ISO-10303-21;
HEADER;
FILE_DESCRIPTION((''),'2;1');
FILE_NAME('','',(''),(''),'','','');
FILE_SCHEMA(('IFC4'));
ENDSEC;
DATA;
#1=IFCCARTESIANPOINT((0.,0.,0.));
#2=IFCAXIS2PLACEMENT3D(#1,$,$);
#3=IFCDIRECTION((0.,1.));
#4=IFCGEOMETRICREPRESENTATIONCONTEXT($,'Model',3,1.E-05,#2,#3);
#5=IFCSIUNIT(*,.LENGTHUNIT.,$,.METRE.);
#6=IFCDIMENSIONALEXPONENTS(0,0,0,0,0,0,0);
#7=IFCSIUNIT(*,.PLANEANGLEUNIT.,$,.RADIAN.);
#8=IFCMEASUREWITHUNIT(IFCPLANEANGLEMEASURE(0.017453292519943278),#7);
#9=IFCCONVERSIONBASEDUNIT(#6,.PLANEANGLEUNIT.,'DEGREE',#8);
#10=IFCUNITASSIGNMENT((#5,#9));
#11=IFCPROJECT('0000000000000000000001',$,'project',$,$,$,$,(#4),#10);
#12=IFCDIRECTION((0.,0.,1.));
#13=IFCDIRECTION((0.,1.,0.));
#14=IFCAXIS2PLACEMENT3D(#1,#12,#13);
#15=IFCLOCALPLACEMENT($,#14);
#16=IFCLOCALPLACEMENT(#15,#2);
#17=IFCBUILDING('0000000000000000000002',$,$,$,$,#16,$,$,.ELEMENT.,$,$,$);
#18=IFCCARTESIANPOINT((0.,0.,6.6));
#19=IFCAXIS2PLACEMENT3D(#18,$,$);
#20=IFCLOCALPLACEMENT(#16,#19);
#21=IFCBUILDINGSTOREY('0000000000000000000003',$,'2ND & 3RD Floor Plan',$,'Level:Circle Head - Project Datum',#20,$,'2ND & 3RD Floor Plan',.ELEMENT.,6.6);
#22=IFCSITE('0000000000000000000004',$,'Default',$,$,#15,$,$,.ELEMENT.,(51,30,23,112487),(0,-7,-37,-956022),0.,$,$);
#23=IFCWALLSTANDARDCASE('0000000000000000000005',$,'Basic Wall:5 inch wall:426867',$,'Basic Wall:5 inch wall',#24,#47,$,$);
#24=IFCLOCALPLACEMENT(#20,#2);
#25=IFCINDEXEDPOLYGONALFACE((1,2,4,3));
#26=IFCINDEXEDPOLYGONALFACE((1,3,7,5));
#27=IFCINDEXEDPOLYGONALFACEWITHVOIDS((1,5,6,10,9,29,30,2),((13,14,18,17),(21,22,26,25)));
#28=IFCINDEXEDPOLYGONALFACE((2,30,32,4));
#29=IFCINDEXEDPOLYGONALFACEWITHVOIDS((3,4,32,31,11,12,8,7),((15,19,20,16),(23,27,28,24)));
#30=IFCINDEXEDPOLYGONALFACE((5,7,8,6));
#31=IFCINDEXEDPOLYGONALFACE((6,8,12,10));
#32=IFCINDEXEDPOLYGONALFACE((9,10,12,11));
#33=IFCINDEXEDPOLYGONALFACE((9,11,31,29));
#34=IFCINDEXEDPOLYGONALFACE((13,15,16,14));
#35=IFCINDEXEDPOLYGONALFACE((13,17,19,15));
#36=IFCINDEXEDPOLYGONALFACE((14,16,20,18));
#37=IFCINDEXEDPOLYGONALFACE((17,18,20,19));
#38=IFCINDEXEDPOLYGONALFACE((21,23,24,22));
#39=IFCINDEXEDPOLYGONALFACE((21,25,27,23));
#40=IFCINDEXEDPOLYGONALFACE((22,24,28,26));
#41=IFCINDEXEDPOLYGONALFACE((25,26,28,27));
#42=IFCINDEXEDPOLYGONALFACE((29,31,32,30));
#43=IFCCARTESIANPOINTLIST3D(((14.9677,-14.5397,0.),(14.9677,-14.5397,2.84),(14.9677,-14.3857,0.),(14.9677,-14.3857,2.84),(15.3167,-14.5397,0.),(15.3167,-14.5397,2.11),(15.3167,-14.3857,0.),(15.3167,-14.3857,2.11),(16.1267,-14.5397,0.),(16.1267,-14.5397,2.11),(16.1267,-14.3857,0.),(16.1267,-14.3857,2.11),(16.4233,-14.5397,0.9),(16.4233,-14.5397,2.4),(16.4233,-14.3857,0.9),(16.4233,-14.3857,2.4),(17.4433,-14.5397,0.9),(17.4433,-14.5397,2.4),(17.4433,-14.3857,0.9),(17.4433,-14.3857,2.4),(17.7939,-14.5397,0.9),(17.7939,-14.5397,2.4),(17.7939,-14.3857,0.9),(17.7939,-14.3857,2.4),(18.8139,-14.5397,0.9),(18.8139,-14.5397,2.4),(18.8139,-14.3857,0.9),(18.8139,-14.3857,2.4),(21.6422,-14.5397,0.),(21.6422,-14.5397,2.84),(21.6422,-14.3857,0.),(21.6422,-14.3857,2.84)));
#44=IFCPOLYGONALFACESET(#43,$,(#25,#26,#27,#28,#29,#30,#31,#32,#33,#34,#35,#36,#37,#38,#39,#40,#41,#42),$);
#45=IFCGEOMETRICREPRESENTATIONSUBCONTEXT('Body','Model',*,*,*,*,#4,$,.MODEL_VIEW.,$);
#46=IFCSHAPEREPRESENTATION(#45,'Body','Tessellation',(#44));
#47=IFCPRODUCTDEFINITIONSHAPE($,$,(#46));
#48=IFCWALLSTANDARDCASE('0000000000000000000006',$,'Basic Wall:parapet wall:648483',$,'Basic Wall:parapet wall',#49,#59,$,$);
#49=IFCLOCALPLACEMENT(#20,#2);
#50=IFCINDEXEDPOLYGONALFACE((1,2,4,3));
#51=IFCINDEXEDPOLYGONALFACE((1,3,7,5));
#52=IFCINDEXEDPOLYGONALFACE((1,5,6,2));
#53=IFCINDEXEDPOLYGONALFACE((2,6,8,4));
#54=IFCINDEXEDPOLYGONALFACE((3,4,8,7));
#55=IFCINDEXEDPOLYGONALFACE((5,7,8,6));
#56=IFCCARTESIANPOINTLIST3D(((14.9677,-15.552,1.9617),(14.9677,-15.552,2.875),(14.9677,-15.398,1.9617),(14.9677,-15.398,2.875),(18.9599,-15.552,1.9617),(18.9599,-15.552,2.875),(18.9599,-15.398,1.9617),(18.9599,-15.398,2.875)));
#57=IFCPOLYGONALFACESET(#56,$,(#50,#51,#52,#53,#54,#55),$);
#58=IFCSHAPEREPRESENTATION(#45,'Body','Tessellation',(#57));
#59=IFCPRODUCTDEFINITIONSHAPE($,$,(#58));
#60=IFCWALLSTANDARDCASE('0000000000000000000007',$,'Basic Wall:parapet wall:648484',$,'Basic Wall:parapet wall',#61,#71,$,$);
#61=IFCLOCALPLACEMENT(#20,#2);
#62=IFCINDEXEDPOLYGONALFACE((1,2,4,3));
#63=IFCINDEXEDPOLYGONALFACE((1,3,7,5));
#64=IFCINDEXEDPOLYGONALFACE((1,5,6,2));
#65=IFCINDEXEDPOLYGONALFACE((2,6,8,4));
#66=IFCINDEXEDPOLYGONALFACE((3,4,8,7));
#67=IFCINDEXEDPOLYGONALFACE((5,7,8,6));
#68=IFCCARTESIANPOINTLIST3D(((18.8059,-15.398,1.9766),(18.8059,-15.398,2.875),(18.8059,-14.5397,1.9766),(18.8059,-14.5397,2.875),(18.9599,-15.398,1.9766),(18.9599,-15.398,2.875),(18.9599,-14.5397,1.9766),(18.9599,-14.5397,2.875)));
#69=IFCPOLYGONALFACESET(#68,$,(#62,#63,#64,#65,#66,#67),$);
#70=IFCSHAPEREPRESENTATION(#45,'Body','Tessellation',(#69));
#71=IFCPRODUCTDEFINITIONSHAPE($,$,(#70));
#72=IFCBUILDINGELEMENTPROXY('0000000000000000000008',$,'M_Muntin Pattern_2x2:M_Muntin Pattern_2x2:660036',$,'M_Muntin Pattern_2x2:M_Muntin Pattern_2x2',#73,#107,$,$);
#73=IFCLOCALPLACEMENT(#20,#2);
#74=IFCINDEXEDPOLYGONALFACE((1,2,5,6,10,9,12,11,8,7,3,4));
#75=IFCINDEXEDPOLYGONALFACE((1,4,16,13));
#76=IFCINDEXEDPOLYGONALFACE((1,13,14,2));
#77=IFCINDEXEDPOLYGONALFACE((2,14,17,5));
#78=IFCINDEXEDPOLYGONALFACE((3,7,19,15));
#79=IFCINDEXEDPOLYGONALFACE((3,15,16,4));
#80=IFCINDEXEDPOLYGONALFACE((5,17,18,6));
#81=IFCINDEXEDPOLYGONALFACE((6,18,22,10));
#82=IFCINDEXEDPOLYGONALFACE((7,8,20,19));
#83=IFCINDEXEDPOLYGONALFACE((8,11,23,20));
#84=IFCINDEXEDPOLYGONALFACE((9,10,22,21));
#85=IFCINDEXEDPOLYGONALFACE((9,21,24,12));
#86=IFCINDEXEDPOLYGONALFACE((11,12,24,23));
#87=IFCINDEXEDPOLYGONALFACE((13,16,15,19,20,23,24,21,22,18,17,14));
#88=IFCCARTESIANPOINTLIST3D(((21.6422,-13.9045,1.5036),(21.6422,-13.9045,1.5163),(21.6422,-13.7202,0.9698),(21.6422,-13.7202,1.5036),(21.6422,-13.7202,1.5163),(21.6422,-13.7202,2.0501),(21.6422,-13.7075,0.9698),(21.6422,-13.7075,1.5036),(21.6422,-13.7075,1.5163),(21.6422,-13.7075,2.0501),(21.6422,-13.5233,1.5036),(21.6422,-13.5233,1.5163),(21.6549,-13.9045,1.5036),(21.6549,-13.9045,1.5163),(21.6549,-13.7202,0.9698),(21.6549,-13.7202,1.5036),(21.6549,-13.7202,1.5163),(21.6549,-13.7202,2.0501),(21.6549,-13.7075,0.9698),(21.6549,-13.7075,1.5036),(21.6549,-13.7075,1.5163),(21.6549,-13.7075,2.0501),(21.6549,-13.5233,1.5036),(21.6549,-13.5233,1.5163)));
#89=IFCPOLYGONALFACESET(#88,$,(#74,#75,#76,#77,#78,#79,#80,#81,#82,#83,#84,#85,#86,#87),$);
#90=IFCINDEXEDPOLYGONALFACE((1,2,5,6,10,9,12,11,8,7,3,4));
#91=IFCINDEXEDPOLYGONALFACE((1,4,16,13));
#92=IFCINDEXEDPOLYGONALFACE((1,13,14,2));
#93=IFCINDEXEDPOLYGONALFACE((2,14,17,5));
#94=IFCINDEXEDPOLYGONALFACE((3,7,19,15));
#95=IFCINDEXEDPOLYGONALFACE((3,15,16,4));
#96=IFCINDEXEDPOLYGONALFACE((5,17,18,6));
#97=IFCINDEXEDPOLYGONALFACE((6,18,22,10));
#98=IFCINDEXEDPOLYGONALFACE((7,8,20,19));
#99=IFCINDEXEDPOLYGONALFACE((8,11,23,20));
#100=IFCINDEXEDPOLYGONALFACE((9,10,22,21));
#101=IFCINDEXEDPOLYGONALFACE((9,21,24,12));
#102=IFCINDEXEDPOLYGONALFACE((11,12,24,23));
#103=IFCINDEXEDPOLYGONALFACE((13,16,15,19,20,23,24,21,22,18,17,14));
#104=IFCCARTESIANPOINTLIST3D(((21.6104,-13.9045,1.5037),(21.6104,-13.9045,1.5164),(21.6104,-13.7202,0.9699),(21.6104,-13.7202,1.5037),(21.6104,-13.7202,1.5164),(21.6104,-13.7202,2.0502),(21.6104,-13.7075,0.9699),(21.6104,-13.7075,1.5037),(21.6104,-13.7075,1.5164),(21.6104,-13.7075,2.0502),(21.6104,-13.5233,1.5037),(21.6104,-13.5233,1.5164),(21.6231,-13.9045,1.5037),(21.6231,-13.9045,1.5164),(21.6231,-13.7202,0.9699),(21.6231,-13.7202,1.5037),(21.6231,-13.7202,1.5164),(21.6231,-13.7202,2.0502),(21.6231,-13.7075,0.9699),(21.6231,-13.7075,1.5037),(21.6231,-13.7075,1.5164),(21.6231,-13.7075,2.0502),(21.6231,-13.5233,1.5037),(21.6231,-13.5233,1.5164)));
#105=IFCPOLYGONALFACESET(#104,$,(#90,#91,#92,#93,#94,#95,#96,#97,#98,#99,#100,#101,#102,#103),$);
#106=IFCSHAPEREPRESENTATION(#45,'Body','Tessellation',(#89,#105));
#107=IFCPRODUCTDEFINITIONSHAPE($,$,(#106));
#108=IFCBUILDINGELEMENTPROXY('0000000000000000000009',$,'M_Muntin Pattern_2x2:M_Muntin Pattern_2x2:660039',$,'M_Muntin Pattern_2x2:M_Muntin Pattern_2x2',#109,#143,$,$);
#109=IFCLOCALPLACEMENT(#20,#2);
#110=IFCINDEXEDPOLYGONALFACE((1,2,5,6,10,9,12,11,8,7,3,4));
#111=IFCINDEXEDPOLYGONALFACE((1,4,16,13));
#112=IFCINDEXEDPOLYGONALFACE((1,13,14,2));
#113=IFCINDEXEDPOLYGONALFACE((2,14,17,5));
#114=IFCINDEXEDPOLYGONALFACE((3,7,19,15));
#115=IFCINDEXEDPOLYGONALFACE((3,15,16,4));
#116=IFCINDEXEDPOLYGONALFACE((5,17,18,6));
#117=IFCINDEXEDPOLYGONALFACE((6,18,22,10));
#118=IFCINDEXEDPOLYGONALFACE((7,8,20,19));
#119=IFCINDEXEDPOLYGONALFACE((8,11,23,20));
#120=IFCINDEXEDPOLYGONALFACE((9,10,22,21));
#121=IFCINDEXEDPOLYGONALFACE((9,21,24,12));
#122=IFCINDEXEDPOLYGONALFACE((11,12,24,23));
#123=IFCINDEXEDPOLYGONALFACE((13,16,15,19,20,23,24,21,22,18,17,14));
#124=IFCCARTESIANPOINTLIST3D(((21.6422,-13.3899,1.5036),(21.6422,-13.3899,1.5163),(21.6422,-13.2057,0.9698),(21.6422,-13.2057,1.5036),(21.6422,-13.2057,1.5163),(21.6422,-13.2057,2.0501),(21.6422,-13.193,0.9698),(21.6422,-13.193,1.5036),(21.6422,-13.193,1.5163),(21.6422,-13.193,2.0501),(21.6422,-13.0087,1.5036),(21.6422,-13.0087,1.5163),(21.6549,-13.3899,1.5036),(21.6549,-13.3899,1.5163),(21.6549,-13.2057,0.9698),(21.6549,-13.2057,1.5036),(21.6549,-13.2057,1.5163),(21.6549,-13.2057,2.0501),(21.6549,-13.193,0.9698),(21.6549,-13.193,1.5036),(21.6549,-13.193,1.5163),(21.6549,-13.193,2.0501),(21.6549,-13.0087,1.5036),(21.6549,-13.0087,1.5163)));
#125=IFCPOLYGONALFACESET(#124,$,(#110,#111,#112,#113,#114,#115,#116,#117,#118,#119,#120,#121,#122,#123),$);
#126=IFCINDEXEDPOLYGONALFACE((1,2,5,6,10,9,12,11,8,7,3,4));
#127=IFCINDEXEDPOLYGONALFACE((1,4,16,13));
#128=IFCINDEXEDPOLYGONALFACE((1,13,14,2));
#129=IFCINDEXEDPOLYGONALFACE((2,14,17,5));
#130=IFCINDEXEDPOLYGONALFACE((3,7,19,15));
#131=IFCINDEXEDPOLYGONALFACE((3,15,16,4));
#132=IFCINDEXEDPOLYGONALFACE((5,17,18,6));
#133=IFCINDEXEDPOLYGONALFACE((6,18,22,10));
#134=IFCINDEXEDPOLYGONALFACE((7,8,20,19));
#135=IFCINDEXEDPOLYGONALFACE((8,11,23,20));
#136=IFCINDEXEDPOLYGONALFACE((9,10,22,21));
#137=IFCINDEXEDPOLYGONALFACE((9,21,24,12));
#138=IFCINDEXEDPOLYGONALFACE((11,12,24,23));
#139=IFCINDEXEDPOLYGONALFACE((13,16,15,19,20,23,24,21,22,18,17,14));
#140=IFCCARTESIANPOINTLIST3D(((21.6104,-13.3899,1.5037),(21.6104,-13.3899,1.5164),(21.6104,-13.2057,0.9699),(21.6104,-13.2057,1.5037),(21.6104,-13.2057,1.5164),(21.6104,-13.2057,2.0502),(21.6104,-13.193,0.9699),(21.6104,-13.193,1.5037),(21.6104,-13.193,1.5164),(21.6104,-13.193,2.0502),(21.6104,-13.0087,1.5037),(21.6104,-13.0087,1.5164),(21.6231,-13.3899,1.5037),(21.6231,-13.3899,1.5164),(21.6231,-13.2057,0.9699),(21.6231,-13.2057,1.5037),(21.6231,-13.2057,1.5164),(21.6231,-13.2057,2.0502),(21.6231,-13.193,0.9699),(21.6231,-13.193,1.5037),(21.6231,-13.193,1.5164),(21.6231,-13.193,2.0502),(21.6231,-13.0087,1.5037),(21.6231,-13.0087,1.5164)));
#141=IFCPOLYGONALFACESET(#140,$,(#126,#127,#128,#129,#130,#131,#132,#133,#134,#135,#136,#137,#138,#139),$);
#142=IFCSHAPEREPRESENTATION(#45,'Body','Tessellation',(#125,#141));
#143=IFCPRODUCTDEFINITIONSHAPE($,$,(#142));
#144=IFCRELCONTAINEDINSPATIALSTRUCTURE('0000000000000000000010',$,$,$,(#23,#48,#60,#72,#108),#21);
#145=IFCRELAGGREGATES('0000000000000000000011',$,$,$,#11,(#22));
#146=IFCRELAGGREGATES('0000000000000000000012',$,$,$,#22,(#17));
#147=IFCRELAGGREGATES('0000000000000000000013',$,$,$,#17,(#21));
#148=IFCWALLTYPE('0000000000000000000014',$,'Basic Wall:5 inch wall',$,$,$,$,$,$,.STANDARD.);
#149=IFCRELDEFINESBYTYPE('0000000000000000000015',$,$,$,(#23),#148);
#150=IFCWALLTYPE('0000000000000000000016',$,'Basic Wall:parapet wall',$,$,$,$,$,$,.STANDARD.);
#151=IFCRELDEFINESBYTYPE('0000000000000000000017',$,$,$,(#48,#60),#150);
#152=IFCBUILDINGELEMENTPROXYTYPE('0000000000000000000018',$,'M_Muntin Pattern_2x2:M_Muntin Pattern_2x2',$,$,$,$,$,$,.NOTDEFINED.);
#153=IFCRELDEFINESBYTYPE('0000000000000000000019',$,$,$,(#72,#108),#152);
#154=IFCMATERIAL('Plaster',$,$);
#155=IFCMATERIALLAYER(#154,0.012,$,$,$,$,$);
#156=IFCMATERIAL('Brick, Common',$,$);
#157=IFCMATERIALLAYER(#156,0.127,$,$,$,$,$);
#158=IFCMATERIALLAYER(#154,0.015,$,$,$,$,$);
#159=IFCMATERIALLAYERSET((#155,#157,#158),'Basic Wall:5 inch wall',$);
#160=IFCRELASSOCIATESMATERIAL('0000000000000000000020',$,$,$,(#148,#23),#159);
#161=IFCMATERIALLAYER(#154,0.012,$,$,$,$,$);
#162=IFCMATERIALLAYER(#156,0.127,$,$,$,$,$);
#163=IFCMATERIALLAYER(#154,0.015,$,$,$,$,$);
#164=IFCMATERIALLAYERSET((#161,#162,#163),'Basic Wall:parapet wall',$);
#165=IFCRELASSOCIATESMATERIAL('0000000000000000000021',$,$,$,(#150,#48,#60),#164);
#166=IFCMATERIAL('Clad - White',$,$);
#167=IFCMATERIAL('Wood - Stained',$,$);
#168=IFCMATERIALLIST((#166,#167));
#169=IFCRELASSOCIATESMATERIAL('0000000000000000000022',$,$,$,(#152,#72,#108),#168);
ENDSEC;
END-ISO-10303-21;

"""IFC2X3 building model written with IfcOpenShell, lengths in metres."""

from ifc_helpers import new_model, entity, si_unit, converted_unit, direction, frame, frame_2d, origin, place, context, subcontext, project, spatial, polyline, rectangle, outline, extrude, clip, bounded_halfspace, source, transform, mapped, material, material_list, layer, layer_set, layer_usage, type_object, type_shapes, element, save


model = new_model("IFC2X3")

# Units and contexts
model_context = context("Model", 3, precision=1e-05, world=origin(), true_north=direction((0.0, 1.0)))
body_context = subcontext(model_context, "Body", "Model", "MODEL_VIEW")
ifc_project = project(units=[si_unit("LENGTHUNIT", "METRE"), converted_unit("PLANEANGLEUNIT", "DEGREE", entity("IfcPlaneAngleMeasure", 0.017453292519943278), si_unit("PLANEANGLEUNIT", "RADIAN"), dimensions=[0, 0, 0, 0, 0, 0, 0])], contexts=[model_context])

# Site, building, storey
site_placement = place(None, frame((0.0, 0.0, 0.0), z_axis=(0.0, 0.0, 1.0), x_axis=(0.0, 1.0, 0.0)))
site = spatial("IfcSite", under=ifc_project, at=site_placement, Name="Default", CompositionType="ELEMENT", RefLatitude=(51, 30, 23, 112487), RefLongitude=(0, -7, -37, -956022), RefElevation=0.0)
building_placement = place(site_placement, origin())
building = spatial("IfcBuilding", under=site, at=building_placement, CompositionType="ELEMENT")
storey_placement = place(building_placement, frame((0.0, 0.0, 6.6)))
storey = spatial("IfcBuildingStorey", under=building, at=storey_placement, Name="2ND & 3RD Floor Plan", ObjectType="Level:Circle Head - Project Datum", LongName="2ND & 3RD Floor Plan", CompositionType="ELEMENT", Elevation=6.6)

# Wall, openings
ifc_material_1 = material(Name="Plaster")
ifc_layer_1 = layer(ifc_material_1, 0.012)
ifc_material_2 = material(Name="Brick, Common")
ifc_layer_2 = layer(ifc_material_2, 0.127)
ifc_layer_3 = layer(ifc_material_1, 0.015)
ifc_layer_set_1 = layer_set([ifc_layer_1, ifc_layer_2, ifc_layer_3], Name="Basic Wall:5 inch wall")
ifc_layer_usage_1 = layer_usage(ifc_layer_set_1, "AXIS2", "POSITIVE", -0.077)
wall_type_1 = type_object("IfcWallType", Name="Basic Wall:5 inch wall", PredefinedType="STANDARD", material=ifc_layer_set_1)
wall_1_placement = place(storey_placement, frame((14.9677, -14.4627, 0.0)))
wall_1 = element("IfcWallStandardCase", 1, at=wall_1_placement, inside=storey, type_object=wall_type_1, material=ifc_layer_usage_1, Name="Basic Wall:5 inch wall:426867", ObjectType="Basic Wall:5 inch wall", context=body_context, shape_type="SweptSolid", body=[
    extrude(rectangle(XDim=6.6745, YDim=0.154, at=frame_2d((3.3372, 0.0), x_axis=(1.0, 0.0))), origin(), (0.0, 0.0, 1.0), 2.84),
])
opening_1_placement = place(wall_1_placement, frame((0.3491, -0.077, 0.0)))
element("IfcOpeningElement", 2, at=opening_1_placement, cuts=wall_1, ObjectType="Opening", context=body_context, shape_type="SweptSolid", body=[
    extrude(rectangle(XDim=2.11, YDim=0.81, at=frame_2d((1.055, 0.405), x_axis=(1.0, 0.0))), frame((0.0, 0.0, 0.0), z_axis=(0.0, 1.0, 0.0), x_axis=(0.0, 0.0, 1.0)), (0.0, 0.0, 1.0), 0.154),
])
opening_2_placement = place(wall_1_placement, frame((2.4757, 0.077, 0.9)))
element("IfcOpeningElement", 3, at=opening_2_placement, cuts=wall_1, ObjectType="Opening", context=body_context, shape_type="SweptSolid", body=[
    extrude(rectangle(XDim=1.5, YDim=1.02, at=frame_2d((0.75, 0.51), x_axis=(-1.0, 0.0))), frame((0.0, 0.0, 0.0), z_axis=(0.0, -1.0, 0.0), x_axis=(0.0, 0.0, 1.0)), (0.0, 0.0, 1.0), 0.154),
])
opening_3_placement = place(wall_1_placement, frame((3.8463, 0.077, 0.9)))
element("IfcOpeningElement", 4, at=opening_3_placement, cuts=wall_1, ObjectType="Opening", context=body_context, shape_type="SweptSolid", body=[
    extrude(rectangle(XDim=1.5, YDim=1.02, at=frame_2d((0.75, 0.51), x_axis=(-1.0, 0.0))), frame((0.0, 0.0, 0.0), z_axis=(0.0, -1.0, 0.0), x_axis=(0.0, 0.0, 1.0)), (0.0, 0.0, 1.0), 0.154),
])

# Walls
ifc_layer_4 = layer(ifc_material_1, 0.012)
ifc_layer_5 = layer(ifc_material_2, 0.127)
ifc_layer_6 = layer(ifc_material_1, 0.015)
ifc_layer_set_2 = layer_set([ifc_layer_4, ifc_layer_5, ifc_layer_6], Name="Basic Wall:parapet wall")
ifc_layer_usage_2 = layer_usage(ifc_layer_set_2, "AXIS2", "NEGATIVE", 0.077)
wall_type_2 = type_object("IfcWallType", Name="Basic Wall:parapet wall", PredefinedType="STANDARD", material=ifc_layer_set_2)
wall_2_placement = place(storey_placement, frame((14.9677, -15.475, 1.9617)))
element("IfcWallStandardCase", 5, at=wall_2_placement, inside=storey, type_object=wall_type_2, material=ifc_layer_usage_2, Name="Basic Wall:parapet wall:648483", ObjectType="Basic Wall:parapet wall", context=body_context, shape_type="Clipping", body=[
    clip(extrude(rectangle(XDim=3.9923, YDim=0.154, at=frame_2d((1.9961, 0.0), x_axis=(-1.0, 0.0))), origin(), (0.0, 0.0, 1.0), 0.9133), bounded_halfspace(frame((0.0, -0.077, 0.9133), z_axis=(0.0, 0.0, -1.0), x_axis=(0.0, -1.0, 0.0)), True, frame((0.0, -0.077, 0.9133)), polyline([(0.0, 0.0), (3.9923, 0.0), (3.9923, 0.154), (3.8383, 0.154), (0.0, 0.154), (0.0, 0.0)]))),
])
ifc_layer_usage_3 = layer_usage(ifc_layer_set_2, "AXIS2", "NEGATIVE", 0.077)
wall_3_placement = place(storey_placement, frame((18.8829, -15.398, 1.9766), z_axis=(0.0, 0.0, 1.0), x_axis=(0.0, 1.0, 0.0)))
element("IfcWallStandardCase", 6, at=wall_3_placement, inside=storey, type_object=wall_type_2, material=ifc_layer_usage_3, Name="Basic Wall:parapet wall:648484", ObjectType="Basic Wall:parapet wall", context=body_context, shape_type="Clipping", body=[
    clip(extrude(rectangle(XDim=0.8583, YDim=0.154, at=frame_2d((0.4291, 0.0), x_axis=(-1.0, 0.0))), origin(), (0.0, 0.0, 1.0), 0.8984), bounded_halfspace(frame((0.0, -0.077, 0.8984), z_axis=(0.0, 0.0, -1.0), x_axis=(-1.0, 0.0, 0.0)), True, frame((0.0, -0.077, 0.8984)), polyline([(0.0, 0.0), (0.8583, 0.0), (0.8583, 0.154), (0.0, 0.154), (0.0, 0.0)]))),
])

# Building element proxies
ifc_material_3 = material(Name="Clad - White")
ifc_material_4 = material(Name="Wood - Stained")
ifc_material_list = material_list([ifc_material_3, ifc_material_4])
building_element_proxy_type_1 = type_object("IfcBuildingElementProxyType", Name="M_Muntin Pattern_2x2:M_Muntin Pattern_2x2", PredefinedType="NOTDEFINED", material=ifc_material_list)
shared_shape_1 = source(origin(), body_context, "Body", "SweptSolid", [
    extrude(outline(polyline([(0.0064, -0.0064), (0.5401, -0.0064), (0.5401, 0.0063), (0.0064, 0.0063), (0.0064, 0.1906), (-0.0063, 0.1906), (-0.0063, 0.0063), (-0.5402, 0.0063), (-0.5402, -0.0064), (-0.0063, -0.0064), (-0.0063, -0.1906), (0.0064, -0.1906), (0.0064, -0.0064)])), frame((0.0, -0.0222, 0.5401), z_axis=(0.0, 1.0, 0.0), x_axis=(0.0, 0.0, 1.0)), (0.0, 0.0, 1.0), 0.0127),
    extrude(outline(polyline([(0.0064, -0.0064), (0.5402, -0.0064), (0.5402, 0.0063), (0.0064, 0.0063), (0.0064, 0.1906), (-0.0063, 0.1906), (-0.0063, 0.0063), (-0.5402, 0.0063), (-0.5402, -0.0064), (-0.0063, -0.0064), (-0.0063, -0.1906), (0.0064, -0.1906), (0.0064, -0.0064)])), frame((0.0, 0.0095, 0.5402), z_axis=(0.0, 1.0, 0.0), x_axis=(0.0, 0.0, 1.0)), (0.0, 0.0, 1.0), 0.0127),
])
type_shapes(building_element_proxy_type_1, [shared_shape_1])
for number, where, z_axis, x_axis, name in (
    (7, (21.6326, -13.7139, 0.9699), (0.0, 0.0, 1.0), (0.0, 1.0, 0.0), "M_Muntin Pattern_2x2:M_Muntin Pattern_2x2:660036"),
    (8, (21.6326, -13.1993, 0.9699), (0.0, 0.0, 1.0), (0.0, 1.0, 0.0), "M_Muntin Pattern_2x2:M_Muntin Pattern_2x2:660039"),
):
    element("IfcBuildingElementProxy", number, at=place(storey_placement, frame(where, z_axis=z_axis, x_axis=x_axis)), inside=storey, type_object=building_element_proxy_type_1, material=ifc_material_list, Name=name, ObjectType="M_Muntin Pattern_2x2:M_Muntin Pattern_2x2", context=body_context, shape_type="MappedRepresentation", body=[
        mapped(shared_shape_1, transform((0.0, 0.0, 0.0), scale=1.0)),
    ])

save(model, "model.ifc")
